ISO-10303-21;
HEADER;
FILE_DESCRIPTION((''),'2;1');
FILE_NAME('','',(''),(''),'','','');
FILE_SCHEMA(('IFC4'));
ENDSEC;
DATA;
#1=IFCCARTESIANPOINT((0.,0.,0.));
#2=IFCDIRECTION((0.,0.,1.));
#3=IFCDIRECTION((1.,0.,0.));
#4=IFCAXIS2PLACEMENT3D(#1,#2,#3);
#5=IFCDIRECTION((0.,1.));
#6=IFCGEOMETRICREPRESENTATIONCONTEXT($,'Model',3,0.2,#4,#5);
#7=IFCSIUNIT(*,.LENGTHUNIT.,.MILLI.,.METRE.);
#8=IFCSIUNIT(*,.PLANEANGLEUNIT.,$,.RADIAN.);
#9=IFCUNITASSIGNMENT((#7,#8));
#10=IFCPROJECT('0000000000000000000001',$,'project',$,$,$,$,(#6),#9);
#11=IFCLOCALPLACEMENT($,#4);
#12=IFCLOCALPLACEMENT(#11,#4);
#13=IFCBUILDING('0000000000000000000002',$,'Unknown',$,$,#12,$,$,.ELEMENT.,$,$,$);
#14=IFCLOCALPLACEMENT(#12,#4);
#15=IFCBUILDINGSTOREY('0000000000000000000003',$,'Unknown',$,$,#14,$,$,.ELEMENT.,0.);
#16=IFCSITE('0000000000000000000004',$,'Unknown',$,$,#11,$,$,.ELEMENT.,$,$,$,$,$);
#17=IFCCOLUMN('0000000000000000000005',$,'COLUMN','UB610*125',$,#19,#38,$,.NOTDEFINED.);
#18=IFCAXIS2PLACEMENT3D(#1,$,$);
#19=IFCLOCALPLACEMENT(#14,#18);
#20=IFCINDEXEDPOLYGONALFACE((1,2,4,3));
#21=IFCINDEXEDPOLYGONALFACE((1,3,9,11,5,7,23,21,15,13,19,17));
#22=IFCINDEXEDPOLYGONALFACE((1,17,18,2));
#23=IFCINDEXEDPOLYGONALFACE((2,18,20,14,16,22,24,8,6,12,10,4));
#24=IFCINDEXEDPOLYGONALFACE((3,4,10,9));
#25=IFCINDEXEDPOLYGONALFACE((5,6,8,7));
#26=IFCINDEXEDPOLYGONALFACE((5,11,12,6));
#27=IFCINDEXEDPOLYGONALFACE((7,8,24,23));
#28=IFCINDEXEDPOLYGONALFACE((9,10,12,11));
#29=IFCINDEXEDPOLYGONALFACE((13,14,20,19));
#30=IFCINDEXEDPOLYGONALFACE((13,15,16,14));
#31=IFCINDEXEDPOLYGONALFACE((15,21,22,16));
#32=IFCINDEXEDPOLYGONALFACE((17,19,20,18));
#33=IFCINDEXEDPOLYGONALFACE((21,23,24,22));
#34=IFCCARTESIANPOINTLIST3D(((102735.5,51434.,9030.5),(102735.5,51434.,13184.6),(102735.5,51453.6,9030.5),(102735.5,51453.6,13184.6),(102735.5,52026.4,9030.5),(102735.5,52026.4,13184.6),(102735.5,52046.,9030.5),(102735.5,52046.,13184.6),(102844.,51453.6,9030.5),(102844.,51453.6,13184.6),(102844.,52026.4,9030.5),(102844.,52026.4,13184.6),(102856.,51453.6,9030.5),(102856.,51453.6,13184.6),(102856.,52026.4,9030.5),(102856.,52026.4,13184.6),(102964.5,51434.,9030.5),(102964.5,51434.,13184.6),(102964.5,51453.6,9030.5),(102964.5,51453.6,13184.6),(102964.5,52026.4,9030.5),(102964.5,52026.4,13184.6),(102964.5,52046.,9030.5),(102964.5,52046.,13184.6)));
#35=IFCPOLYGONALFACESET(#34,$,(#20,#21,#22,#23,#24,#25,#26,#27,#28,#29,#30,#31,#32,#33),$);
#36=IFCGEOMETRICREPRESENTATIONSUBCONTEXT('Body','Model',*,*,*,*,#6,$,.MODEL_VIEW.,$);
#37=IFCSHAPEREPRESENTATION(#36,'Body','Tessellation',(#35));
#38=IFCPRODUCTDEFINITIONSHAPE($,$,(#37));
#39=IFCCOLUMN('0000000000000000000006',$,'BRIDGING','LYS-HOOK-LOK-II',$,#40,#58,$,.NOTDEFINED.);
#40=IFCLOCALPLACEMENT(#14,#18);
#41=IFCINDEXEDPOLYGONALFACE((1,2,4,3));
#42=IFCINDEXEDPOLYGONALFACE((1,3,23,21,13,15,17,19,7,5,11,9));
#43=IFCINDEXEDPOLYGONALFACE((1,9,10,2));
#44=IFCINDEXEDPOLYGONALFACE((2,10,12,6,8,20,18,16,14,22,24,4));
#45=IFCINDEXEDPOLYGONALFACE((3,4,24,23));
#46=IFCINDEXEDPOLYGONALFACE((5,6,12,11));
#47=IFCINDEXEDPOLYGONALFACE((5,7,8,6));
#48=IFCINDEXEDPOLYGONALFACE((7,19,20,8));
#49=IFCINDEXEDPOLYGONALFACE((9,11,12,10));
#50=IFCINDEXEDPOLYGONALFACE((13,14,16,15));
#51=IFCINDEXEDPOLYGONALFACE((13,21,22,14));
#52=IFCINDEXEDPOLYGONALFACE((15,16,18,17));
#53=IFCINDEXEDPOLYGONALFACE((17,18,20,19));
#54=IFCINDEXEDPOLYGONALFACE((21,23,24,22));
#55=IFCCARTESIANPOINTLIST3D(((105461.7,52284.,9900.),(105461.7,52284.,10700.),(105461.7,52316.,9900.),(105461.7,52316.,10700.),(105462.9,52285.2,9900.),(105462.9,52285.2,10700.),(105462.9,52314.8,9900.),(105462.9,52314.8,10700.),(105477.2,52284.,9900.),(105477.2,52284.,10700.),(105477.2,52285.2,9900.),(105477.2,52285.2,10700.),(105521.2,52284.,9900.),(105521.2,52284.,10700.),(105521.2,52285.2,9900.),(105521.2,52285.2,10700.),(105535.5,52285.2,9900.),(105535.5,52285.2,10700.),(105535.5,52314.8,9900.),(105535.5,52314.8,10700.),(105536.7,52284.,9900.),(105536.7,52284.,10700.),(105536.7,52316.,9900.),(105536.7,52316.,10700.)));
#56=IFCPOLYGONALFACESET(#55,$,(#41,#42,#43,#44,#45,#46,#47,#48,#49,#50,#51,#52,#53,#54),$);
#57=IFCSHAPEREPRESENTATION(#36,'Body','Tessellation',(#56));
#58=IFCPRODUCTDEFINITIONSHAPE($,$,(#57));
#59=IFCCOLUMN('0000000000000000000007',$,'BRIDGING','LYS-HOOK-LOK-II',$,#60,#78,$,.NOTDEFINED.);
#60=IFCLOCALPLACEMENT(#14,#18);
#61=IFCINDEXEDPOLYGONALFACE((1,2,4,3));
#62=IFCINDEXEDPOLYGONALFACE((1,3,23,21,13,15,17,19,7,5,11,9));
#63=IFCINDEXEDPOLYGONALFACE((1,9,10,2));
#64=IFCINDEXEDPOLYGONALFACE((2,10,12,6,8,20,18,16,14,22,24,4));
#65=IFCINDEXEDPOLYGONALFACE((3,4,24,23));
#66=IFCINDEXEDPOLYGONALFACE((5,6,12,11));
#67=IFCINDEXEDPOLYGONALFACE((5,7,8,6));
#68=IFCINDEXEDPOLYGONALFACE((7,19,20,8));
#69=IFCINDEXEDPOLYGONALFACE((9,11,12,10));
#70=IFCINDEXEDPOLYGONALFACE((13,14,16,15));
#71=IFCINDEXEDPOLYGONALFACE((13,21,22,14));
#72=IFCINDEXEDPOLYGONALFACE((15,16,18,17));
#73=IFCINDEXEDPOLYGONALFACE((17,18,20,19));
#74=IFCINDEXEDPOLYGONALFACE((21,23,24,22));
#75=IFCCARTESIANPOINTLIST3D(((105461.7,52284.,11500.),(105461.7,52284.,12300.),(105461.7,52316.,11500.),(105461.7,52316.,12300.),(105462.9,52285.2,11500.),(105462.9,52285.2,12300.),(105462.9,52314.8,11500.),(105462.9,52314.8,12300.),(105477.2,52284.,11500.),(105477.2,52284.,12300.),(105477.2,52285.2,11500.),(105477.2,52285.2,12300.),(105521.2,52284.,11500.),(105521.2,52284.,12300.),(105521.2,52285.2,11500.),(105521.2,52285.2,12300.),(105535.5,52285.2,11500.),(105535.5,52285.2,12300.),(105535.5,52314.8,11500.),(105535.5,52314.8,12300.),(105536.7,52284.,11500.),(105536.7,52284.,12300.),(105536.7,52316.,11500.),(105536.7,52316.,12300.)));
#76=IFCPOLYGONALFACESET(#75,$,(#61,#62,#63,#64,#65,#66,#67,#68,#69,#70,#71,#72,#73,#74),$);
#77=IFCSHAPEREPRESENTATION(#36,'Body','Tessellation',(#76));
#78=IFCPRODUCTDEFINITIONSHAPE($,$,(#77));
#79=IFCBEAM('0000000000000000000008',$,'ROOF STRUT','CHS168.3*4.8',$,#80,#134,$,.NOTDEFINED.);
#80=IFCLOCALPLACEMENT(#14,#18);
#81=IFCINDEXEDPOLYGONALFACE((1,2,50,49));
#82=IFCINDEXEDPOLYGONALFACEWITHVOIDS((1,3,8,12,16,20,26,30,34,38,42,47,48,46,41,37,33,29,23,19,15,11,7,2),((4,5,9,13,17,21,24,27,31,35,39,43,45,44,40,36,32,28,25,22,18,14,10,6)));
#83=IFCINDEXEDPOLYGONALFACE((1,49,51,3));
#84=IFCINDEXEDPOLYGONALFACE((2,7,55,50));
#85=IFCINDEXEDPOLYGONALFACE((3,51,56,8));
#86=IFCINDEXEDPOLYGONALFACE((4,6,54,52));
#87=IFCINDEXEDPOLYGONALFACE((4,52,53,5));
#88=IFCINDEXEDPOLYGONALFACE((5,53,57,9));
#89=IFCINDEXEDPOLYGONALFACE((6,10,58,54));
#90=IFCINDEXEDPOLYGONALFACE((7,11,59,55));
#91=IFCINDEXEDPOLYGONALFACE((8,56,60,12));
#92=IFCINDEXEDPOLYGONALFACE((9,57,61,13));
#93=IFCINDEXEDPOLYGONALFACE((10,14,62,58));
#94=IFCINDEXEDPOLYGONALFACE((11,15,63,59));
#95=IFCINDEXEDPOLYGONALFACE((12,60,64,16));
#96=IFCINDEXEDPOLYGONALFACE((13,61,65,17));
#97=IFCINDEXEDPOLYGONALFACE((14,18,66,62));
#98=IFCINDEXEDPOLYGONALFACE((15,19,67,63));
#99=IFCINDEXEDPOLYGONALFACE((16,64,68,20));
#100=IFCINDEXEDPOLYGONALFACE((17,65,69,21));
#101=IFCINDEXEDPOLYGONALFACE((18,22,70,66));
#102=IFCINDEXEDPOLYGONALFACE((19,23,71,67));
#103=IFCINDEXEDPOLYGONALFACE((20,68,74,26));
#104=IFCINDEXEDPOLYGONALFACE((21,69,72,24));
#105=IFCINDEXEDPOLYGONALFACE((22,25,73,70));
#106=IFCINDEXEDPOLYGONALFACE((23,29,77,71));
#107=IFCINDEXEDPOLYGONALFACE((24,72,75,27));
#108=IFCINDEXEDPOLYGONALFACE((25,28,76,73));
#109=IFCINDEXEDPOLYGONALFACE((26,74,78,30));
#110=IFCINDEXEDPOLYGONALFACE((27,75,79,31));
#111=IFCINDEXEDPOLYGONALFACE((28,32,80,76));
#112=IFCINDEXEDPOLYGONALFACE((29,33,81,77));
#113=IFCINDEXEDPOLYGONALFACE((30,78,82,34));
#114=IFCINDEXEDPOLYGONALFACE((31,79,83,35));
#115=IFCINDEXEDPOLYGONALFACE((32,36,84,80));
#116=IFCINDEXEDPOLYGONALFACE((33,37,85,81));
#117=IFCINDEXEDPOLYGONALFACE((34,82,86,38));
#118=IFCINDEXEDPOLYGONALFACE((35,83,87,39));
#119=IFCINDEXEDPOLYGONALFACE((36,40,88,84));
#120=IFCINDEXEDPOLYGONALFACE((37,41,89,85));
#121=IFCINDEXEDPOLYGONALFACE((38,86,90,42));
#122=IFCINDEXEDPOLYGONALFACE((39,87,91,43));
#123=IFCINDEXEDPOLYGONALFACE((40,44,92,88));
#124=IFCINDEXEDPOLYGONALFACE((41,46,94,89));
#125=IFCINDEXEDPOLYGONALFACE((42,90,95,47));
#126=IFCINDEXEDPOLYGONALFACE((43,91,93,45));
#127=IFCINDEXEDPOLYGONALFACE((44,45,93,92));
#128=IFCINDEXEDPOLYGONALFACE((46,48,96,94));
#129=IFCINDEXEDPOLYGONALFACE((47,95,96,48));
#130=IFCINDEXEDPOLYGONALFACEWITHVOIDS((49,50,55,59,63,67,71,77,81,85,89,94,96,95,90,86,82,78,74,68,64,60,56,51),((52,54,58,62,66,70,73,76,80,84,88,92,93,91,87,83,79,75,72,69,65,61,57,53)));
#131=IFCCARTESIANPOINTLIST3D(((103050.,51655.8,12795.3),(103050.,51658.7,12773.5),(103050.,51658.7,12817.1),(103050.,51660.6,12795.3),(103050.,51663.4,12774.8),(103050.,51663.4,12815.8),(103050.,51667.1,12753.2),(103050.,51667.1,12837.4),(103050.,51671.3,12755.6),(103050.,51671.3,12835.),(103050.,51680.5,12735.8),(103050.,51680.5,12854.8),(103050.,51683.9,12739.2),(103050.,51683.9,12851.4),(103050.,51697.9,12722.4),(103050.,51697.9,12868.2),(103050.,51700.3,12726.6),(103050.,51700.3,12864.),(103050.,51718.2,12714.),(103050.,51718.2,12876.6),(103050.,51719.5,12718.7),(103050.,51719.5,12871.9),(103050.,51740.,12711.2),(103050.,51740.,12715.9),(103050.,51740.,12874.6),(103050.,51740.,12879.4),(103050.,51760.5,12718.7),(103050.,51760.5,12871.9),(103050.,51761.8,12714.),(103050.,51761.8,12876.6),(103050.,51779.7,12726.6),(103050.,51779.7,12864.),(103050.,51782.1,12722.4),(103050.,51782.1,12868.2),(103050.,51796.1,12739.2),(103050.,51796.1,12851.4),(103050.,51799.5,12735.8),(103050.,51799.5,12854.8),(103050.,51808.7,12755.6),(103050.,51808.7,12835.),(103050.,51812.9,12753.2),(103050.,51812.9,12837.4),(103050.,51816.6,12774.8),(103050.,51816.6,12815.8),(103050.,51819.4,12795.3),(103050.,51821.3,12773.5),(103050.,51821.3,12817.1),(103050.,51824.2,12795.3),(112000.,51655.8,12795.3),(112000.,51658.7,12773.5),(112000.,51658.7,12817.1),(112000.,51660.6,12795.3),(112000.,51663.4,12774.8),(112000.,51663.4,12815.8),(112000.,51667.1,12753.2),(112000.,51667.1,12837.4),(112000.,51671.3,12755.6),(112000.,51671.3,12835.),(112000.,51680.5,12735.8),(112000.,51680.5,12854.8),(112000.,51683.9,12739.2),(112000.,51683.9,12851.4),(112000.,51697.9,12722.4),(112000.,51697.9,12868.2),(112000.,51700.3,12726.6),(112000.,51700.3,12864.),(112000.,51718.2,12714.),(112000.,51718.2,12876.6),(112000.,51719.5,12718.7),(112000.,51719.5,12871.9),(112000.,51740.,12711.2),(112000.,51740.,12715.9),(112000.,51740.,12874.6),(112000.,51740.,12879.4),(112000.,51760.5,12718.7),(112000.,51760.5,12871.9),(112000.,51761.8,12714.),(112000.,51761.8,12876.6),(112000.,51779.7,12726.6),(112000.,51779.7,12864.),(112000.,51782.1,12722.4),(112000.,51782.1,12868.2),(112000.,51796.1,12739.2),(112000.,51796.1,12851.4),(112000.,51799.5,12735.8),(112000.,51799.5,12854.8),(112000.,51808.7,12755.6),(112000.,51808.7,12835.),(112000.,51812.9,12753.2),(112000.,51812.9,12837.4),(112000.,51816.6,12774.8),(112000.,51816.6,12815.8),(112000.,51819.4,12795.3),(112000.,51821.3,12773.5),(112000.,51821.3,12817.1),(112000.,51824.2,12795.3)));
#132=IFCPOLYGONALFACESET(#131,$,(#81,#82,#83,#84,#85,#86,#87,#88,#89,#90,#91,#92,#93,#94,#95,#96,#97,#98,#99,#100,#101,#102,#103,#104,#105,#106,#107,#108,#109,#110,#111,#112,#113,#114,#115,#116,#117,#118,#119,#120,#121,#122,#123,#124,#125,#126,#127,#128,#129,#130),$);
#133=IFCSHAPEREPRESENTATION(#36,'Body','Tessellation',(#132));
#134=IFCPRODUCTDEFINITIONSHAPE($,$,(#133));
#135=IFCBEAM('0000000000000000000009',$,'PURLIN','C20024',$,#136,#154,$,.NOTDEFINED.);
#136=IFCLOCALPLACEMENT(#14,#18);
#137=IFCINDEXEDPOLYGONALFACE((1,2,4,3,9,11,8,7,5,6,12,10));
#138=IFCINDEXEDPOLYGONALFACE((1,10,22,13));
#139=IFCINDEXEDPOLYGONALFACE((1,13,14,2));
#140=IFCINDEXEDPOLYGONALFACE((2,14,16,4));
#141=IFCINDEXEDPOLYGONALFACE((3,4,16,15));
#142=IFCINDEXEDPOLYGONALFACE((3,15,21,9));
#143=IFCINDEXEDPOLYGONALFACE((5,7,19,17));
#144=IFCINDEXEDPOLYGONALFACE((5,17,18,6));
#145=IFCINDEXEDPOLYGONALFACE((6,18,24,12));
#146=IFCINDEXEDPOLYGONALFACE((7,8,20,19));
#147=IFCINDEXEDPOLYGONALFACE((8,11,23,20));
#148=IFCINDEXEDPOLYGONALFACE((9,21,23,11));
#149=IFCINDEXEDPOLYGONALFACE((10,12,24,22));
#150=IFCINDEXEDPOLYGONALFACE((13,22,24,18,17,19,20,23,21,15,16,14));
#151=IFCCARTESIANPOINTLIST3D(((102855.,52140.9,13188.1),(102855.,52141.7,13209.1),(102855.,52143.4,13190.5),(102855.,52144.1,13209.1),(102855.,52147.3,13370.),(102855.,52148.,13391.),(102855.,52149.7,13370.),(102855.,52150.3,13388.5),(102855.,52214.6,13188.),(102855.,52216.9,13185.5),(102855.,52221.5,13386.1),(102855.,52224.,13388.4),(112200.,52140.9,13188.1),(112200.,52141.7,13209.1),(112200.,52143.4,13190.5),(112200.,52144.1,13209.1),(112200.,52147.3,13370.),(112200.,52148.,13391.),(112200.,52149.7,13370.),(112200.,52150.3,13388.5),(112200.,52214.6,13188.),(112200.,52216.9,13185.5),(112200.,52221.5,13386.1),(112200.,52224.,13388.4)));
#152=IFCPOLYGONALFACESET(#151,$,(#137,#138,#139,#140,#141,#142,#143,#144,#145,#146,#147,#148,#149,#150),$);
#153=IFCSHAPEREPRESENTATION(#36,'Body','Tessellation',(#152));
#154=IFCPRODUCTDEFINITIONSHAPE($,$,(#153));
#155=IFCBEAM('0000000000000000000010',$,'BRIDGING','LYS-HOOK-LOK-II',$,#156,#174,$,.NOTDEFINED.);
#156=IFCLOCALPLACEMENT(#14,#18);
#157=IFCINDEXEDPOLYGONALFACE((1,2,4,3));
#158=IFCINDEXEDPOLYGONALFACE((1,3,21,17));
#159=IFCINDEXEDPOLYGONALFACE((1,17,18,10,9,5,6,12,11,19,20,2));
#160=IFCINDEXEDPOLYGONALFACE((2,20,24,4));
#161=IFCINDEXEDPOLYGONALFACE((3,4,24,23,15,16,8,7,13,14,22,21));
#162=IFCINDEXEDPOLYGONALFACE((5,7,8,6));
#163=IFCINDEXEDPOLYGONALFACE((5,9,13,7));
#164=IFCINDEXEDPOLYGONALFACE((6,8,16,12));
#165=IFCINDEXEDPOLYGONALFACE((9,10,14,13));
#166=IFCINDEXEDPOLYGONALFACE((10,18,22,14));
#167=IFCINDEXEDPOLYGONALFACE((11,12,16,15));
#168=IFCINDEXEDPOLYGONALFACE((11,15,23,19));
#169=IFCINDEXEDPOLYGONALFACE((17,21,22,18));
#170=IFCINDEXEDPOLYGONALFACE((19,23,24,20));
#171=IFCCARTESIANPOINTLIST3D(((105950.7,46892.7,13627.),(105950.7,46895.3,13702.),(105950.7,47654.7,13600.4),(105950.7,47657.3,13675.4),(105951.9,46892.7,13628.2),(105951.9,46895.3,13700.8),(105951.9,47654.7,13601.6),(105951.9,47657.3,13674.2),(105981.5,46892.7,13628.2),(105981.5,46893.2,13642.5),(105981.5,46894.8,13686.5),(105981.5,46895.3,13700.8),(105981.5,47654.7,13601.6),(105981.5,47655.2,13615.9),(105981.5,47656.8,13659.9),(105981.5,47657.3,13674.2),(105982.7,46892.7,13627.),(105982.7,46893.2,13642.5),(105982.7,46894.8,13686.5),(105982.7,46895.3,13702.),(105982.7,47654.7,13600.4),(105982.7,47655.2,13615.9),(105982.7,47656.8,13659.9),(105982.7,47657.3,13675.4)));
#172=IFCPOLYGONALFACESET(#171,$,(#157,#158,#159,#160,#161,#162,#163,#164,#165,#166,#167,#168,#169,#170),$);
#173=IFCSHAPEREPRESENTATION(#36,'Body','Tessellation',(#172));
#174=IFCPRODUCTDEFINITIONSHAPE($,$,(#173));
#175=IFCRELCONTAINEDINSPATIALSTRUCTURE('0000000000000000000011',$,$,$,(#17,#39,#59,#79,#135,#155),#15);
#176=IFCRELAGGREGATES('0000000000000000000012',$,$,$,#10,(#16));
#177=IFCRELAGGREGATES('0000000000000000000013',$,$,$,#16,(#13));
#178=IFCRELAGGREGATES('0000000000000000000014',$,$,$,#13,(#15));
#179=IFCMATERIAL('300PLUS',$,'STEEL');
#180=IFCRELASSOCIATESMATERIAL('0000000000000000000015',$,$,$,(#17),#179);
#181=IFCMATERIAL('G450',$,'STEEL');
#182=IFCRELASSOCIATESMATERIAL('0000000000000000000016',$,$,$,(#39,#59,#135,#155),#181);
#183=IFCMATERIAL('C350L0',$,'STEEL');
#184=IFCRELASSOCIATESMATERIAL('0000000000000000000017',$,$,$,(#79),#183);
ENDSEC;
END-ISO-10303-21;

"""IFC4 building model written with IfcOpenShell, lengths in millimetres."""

from ifc_helpers import new_model, si_unit, direction, frame, origin_with_axes, place, context, subcontext, project, spatial, line, indexed_curve, outline, extrude, material, element, save


model = new_model("IFC4")

# Units and contexts
model_context = context("Model", 3, precision=0.2, world=origin_with_axes(), true_north=direction((0.0, 1.0)))
body_context = subcontext(model_context, "Body", "Model", "MODEL_VIEW")
ifc_project = project(units=[si_unit("LENGTHUNIT", "METRE", prefix="MILLI"), si_unit("PLANEANGLEUNIT", "RADIAN")], contexts=[model_context])

# Site, building, storey
site_placement = place(None, origin_with_axes())
site = spatial("IfcSite", under=ifc_project, at=site_placement, Name="Unknown", CompositionType="ELEMENT")
building_placement = place(site_placement, origin_with_axes())
building = spatial("IfcBuilding", under=site, at=building_placement, Name="Unknown", CompositionType="ELEMENT")
storey_placement = place(building_placement, origin_with_axes())
storey = spatial("IfcBuildingStorey", under=building, at=storey_placement, Name="Unknown", CompositionType="ELEMENT", Elevation=0.0)

# Columns
ifc_material_1 = material(Name="300PLUS", Category="STEEL")
column_placement = place(storey_placement, frame((102850.0, 51740.0, 9030.5), z_axis=(-1.0, 0.0, 0.0), x_axis=(0.0, 0.0, 1.0)))
element("IfcColumn", 1, at=column_placement, inside=storey, material=ifc_material_1, Name="COLUMN", Description="UB610*125", PredefinedType="NOTDEFINED", context=body_context, shape_type="SolidModel", body=[
    extrude(outline(indexed_curve([(-114.5, -306.0), (114.5, -306.0), (114.5, -286.4), (6.0, -286.4), (6.0, 286.4), (114.5, 286.4), (114.5, 306.0), (-114.5, 306.0), (-114.5, 286.4), (-6.0, 286.4), (-6.0, -286.4), (-114.5, -286.4)], segments=[line(1, 2, 3, 4, 5, 6, 7, 8, 9, 10, 11, 12, 1)])), frame((0.0, 0.0, 0.0), z_axis=(-1.0, 0.0, 0.0), x_axis=(0.0, 0.0, 1.0)), (0.0, 0.0, -1.0), 4154.1),
])
ifc_material_2 = material(Name="G450", Category="STEEL")
for number, where, z_axis, x_axis, name in (
    (2, (105499.2, 52300.0, 9900.0), (0.0, -1.0, 0.0), (0.0, 0.0, 1.0), "BRIDGING"),
    (3, (105499.2, 52300.0, 11500.0), (0.0, -1.0, 0.0), (0.0, 0.0, 1.0), "BRIDGING"),
):
    element("IfcColumn", number, at=place(storey_placement, frame(where, z_axis=z_axis, x_axis=x_axis)), inside=storey, material=ifc_material_2, Name=name, Description="LYS-HOOK-LOK-II", PredefinedType="NOTDEFINED", context=body_context, shape_type="SolidModel", body=[
        extrude(outline(indexed_curve([(16.0, -37.5), (16.0, -22.0), (14.8, -22.0), (14.8, -36.3), (-14.8, -36.3), (-14.8, 36.3), (14.8, 36.3), (14.8, 22.0), (16.0, 22.0), (16.0, 37.5), (-16.0, 37.5), (-16.0, -37.5)], segments=[line(1, 2, 3, 4, 5, 6, 7, 8, 9, 10, 11, 12, 1)])), frame((0.0, 0.0, 0.0), z_axis=(-1.0, 0.0, 0.0), x_axis=(0.0, 0.0, 1.0)), (0.0, 0.0, -1.0), 800.0),
    ])

# Beams
ifc_material_3 = material(Name="C350L0", Category="STEEL")
beam_1_placement = place(storey_placement, frame((103050.0, 51740.0, 12795.3), z_axis=(0.0, 0.0, 1.0), x_axis=(1.0, 0.0, 0.0)))
element("IfcBeam", 4, at=beam_1_placement, inside=storey, material=ifc_material_3, Name="ROOF STRUT", Description="CHS168.3*4.8", PredefinedType="NOTDEFINED", context=body_context, shape_type="SolidModel", body=[
    extrude(outline(indexed_curve([(84.2, 0.0), (81.3, 21.8), (72.9, 42.1), (59.5, 59.5), (42.1, 72.9), (21.8, 81.3), (0.0, 84.2), (-21.8, 81.3), (-42.1, 72.9), (-59.5, 59.5), (-72.9, 42.1), (-81.3, 21.8), (-84.2, 0.0), (-81.3, -21.8), (-72.9, -42.1), (-59.5, -59.5), (-42.1, -72.9), (-21.8, -81.3), (0.0, -84.2), (21.8, -81.3), (42.1, -72.9), (59.5, -59.5), (72.9, -42.1), (81.3, -21.8)], segments=[line(1, 2, 3, 4, 5, 6, 7, 8, 9, 10, 11, 12, 13, 14, 15, 16, 17, 18, 19, 20, 21, 22, 23, 24, 1)]), holes=[indexed_curve([(79.3, 0.0), (76.6, -20.5), (68.7, -39.7), (56.1, -56.1), (39.7, -68.7), (20.5, -76.6), (0.0, -79.3), (-20.5, -76.6), (-39.7, -68.7), (-56.1, -56.1), (-68.7, -39.7), (-76.6, -20.5), (-79.3, 0.0), (-76.6, 20.5), (-68.7, 39.7), (-56.1, 56.1), (-39.7, 68.7), (-20.5, 76.6), (0.0, 79.3), (20.5, 76.6), (39.7, 68.7), (56.1, 56.1), (68.7, 39.7), (76.6, 20.5)], segments=[line(1, 2, 3, 4, 5, 6, 7, 8, 9, 10, 11, 12, 13, 14, 15, 16, 17, 18, 19, 20, 21, 22, 23, 24, 1)])]), frame((0.0, 0.0, 0.0), z_axis=(-1.0, 0.0, 0.0), x_axis=(0.0, 0.0, 1.0)), (0.0, 0.0, -1.0), 8950.0),
])
beam_2_placement = place(storey_placement, frame((102855.0, 52182.5, 13288.3), z_axis=(0.0, -0.999391, 0.034899), x_axis=(1.0, 0.0, 0.0)))
element("IfcBeam", 5, at=beam_2_placement, inside=storey, material=ifc_material_2, Name="PURLIN", Description="C20024", PredefinedType="NOTDEFINED", context=body_context, shape_type="SolidModel", body=[
    extrude(outline(indexed_curve([(38.0, -101.5), (38.0, -80.5), (35.6, -80.5), (35.6, -99.1), (-35.6, -99.1), (-35.6, 99.1), (35.6, 99.1), (35.6, 80.5), (38.0, 80.5), (38.0, 101.5), (-38.0, 101.5), (-38.0, -101.5)], segments=[line(1, 2, 3, 4, 5, 6, 7, 8, 9, 10, 11, 12, 1)])), frame((0.0, 0.0, 0.0), z_axis=(-1.0, 0.0, 0.0), x_axis=(0.0, 0.0, 1.0)), (0.0, 0.0, -1.0), 9345.0),
])
beam_3_placement = place(storey_placement, frame((105966.7, 46894.0, 13664.5), z_axis=(1.0, 0.0, 0.0), x_axis=(0.0, 0.999391, -0.034887)))
element("IfcBeam", 6, at=beam_3_placement, inside=storey, material=ifc_material_2, Name="BRIDGING", Description="LYS-HOOK-LOK-II", PredefinedType="NOTDEFINED", context=body_context, shape_type="SolidModel", body=[
    extrude(outline(indexed_curve([(16.0, -37.5), (16.0, -22.0), (14.8, -22.0), (14.8, -36.3), (-14.8, -36.3), (-14.8, 36.3), (14.8, 36.3), (14.8, 22.0), (16.0, 22.0), (16.0, 37.5), (-16.0, 37.5), (-16.0, -37.5)], segments=[line(1, 2, 3, 4, 5, 6, 7, 8, 9, 10, 11, 12, 1)])), frame((0.0, 0.0, 0.0), z_axis=(-1.0, 0.0, 0.0), x_axis=(0.0, 0.0, 1.0)), (0.0, 0.0, -1.0), 762.5),
])

save(model, "model.ifc")
